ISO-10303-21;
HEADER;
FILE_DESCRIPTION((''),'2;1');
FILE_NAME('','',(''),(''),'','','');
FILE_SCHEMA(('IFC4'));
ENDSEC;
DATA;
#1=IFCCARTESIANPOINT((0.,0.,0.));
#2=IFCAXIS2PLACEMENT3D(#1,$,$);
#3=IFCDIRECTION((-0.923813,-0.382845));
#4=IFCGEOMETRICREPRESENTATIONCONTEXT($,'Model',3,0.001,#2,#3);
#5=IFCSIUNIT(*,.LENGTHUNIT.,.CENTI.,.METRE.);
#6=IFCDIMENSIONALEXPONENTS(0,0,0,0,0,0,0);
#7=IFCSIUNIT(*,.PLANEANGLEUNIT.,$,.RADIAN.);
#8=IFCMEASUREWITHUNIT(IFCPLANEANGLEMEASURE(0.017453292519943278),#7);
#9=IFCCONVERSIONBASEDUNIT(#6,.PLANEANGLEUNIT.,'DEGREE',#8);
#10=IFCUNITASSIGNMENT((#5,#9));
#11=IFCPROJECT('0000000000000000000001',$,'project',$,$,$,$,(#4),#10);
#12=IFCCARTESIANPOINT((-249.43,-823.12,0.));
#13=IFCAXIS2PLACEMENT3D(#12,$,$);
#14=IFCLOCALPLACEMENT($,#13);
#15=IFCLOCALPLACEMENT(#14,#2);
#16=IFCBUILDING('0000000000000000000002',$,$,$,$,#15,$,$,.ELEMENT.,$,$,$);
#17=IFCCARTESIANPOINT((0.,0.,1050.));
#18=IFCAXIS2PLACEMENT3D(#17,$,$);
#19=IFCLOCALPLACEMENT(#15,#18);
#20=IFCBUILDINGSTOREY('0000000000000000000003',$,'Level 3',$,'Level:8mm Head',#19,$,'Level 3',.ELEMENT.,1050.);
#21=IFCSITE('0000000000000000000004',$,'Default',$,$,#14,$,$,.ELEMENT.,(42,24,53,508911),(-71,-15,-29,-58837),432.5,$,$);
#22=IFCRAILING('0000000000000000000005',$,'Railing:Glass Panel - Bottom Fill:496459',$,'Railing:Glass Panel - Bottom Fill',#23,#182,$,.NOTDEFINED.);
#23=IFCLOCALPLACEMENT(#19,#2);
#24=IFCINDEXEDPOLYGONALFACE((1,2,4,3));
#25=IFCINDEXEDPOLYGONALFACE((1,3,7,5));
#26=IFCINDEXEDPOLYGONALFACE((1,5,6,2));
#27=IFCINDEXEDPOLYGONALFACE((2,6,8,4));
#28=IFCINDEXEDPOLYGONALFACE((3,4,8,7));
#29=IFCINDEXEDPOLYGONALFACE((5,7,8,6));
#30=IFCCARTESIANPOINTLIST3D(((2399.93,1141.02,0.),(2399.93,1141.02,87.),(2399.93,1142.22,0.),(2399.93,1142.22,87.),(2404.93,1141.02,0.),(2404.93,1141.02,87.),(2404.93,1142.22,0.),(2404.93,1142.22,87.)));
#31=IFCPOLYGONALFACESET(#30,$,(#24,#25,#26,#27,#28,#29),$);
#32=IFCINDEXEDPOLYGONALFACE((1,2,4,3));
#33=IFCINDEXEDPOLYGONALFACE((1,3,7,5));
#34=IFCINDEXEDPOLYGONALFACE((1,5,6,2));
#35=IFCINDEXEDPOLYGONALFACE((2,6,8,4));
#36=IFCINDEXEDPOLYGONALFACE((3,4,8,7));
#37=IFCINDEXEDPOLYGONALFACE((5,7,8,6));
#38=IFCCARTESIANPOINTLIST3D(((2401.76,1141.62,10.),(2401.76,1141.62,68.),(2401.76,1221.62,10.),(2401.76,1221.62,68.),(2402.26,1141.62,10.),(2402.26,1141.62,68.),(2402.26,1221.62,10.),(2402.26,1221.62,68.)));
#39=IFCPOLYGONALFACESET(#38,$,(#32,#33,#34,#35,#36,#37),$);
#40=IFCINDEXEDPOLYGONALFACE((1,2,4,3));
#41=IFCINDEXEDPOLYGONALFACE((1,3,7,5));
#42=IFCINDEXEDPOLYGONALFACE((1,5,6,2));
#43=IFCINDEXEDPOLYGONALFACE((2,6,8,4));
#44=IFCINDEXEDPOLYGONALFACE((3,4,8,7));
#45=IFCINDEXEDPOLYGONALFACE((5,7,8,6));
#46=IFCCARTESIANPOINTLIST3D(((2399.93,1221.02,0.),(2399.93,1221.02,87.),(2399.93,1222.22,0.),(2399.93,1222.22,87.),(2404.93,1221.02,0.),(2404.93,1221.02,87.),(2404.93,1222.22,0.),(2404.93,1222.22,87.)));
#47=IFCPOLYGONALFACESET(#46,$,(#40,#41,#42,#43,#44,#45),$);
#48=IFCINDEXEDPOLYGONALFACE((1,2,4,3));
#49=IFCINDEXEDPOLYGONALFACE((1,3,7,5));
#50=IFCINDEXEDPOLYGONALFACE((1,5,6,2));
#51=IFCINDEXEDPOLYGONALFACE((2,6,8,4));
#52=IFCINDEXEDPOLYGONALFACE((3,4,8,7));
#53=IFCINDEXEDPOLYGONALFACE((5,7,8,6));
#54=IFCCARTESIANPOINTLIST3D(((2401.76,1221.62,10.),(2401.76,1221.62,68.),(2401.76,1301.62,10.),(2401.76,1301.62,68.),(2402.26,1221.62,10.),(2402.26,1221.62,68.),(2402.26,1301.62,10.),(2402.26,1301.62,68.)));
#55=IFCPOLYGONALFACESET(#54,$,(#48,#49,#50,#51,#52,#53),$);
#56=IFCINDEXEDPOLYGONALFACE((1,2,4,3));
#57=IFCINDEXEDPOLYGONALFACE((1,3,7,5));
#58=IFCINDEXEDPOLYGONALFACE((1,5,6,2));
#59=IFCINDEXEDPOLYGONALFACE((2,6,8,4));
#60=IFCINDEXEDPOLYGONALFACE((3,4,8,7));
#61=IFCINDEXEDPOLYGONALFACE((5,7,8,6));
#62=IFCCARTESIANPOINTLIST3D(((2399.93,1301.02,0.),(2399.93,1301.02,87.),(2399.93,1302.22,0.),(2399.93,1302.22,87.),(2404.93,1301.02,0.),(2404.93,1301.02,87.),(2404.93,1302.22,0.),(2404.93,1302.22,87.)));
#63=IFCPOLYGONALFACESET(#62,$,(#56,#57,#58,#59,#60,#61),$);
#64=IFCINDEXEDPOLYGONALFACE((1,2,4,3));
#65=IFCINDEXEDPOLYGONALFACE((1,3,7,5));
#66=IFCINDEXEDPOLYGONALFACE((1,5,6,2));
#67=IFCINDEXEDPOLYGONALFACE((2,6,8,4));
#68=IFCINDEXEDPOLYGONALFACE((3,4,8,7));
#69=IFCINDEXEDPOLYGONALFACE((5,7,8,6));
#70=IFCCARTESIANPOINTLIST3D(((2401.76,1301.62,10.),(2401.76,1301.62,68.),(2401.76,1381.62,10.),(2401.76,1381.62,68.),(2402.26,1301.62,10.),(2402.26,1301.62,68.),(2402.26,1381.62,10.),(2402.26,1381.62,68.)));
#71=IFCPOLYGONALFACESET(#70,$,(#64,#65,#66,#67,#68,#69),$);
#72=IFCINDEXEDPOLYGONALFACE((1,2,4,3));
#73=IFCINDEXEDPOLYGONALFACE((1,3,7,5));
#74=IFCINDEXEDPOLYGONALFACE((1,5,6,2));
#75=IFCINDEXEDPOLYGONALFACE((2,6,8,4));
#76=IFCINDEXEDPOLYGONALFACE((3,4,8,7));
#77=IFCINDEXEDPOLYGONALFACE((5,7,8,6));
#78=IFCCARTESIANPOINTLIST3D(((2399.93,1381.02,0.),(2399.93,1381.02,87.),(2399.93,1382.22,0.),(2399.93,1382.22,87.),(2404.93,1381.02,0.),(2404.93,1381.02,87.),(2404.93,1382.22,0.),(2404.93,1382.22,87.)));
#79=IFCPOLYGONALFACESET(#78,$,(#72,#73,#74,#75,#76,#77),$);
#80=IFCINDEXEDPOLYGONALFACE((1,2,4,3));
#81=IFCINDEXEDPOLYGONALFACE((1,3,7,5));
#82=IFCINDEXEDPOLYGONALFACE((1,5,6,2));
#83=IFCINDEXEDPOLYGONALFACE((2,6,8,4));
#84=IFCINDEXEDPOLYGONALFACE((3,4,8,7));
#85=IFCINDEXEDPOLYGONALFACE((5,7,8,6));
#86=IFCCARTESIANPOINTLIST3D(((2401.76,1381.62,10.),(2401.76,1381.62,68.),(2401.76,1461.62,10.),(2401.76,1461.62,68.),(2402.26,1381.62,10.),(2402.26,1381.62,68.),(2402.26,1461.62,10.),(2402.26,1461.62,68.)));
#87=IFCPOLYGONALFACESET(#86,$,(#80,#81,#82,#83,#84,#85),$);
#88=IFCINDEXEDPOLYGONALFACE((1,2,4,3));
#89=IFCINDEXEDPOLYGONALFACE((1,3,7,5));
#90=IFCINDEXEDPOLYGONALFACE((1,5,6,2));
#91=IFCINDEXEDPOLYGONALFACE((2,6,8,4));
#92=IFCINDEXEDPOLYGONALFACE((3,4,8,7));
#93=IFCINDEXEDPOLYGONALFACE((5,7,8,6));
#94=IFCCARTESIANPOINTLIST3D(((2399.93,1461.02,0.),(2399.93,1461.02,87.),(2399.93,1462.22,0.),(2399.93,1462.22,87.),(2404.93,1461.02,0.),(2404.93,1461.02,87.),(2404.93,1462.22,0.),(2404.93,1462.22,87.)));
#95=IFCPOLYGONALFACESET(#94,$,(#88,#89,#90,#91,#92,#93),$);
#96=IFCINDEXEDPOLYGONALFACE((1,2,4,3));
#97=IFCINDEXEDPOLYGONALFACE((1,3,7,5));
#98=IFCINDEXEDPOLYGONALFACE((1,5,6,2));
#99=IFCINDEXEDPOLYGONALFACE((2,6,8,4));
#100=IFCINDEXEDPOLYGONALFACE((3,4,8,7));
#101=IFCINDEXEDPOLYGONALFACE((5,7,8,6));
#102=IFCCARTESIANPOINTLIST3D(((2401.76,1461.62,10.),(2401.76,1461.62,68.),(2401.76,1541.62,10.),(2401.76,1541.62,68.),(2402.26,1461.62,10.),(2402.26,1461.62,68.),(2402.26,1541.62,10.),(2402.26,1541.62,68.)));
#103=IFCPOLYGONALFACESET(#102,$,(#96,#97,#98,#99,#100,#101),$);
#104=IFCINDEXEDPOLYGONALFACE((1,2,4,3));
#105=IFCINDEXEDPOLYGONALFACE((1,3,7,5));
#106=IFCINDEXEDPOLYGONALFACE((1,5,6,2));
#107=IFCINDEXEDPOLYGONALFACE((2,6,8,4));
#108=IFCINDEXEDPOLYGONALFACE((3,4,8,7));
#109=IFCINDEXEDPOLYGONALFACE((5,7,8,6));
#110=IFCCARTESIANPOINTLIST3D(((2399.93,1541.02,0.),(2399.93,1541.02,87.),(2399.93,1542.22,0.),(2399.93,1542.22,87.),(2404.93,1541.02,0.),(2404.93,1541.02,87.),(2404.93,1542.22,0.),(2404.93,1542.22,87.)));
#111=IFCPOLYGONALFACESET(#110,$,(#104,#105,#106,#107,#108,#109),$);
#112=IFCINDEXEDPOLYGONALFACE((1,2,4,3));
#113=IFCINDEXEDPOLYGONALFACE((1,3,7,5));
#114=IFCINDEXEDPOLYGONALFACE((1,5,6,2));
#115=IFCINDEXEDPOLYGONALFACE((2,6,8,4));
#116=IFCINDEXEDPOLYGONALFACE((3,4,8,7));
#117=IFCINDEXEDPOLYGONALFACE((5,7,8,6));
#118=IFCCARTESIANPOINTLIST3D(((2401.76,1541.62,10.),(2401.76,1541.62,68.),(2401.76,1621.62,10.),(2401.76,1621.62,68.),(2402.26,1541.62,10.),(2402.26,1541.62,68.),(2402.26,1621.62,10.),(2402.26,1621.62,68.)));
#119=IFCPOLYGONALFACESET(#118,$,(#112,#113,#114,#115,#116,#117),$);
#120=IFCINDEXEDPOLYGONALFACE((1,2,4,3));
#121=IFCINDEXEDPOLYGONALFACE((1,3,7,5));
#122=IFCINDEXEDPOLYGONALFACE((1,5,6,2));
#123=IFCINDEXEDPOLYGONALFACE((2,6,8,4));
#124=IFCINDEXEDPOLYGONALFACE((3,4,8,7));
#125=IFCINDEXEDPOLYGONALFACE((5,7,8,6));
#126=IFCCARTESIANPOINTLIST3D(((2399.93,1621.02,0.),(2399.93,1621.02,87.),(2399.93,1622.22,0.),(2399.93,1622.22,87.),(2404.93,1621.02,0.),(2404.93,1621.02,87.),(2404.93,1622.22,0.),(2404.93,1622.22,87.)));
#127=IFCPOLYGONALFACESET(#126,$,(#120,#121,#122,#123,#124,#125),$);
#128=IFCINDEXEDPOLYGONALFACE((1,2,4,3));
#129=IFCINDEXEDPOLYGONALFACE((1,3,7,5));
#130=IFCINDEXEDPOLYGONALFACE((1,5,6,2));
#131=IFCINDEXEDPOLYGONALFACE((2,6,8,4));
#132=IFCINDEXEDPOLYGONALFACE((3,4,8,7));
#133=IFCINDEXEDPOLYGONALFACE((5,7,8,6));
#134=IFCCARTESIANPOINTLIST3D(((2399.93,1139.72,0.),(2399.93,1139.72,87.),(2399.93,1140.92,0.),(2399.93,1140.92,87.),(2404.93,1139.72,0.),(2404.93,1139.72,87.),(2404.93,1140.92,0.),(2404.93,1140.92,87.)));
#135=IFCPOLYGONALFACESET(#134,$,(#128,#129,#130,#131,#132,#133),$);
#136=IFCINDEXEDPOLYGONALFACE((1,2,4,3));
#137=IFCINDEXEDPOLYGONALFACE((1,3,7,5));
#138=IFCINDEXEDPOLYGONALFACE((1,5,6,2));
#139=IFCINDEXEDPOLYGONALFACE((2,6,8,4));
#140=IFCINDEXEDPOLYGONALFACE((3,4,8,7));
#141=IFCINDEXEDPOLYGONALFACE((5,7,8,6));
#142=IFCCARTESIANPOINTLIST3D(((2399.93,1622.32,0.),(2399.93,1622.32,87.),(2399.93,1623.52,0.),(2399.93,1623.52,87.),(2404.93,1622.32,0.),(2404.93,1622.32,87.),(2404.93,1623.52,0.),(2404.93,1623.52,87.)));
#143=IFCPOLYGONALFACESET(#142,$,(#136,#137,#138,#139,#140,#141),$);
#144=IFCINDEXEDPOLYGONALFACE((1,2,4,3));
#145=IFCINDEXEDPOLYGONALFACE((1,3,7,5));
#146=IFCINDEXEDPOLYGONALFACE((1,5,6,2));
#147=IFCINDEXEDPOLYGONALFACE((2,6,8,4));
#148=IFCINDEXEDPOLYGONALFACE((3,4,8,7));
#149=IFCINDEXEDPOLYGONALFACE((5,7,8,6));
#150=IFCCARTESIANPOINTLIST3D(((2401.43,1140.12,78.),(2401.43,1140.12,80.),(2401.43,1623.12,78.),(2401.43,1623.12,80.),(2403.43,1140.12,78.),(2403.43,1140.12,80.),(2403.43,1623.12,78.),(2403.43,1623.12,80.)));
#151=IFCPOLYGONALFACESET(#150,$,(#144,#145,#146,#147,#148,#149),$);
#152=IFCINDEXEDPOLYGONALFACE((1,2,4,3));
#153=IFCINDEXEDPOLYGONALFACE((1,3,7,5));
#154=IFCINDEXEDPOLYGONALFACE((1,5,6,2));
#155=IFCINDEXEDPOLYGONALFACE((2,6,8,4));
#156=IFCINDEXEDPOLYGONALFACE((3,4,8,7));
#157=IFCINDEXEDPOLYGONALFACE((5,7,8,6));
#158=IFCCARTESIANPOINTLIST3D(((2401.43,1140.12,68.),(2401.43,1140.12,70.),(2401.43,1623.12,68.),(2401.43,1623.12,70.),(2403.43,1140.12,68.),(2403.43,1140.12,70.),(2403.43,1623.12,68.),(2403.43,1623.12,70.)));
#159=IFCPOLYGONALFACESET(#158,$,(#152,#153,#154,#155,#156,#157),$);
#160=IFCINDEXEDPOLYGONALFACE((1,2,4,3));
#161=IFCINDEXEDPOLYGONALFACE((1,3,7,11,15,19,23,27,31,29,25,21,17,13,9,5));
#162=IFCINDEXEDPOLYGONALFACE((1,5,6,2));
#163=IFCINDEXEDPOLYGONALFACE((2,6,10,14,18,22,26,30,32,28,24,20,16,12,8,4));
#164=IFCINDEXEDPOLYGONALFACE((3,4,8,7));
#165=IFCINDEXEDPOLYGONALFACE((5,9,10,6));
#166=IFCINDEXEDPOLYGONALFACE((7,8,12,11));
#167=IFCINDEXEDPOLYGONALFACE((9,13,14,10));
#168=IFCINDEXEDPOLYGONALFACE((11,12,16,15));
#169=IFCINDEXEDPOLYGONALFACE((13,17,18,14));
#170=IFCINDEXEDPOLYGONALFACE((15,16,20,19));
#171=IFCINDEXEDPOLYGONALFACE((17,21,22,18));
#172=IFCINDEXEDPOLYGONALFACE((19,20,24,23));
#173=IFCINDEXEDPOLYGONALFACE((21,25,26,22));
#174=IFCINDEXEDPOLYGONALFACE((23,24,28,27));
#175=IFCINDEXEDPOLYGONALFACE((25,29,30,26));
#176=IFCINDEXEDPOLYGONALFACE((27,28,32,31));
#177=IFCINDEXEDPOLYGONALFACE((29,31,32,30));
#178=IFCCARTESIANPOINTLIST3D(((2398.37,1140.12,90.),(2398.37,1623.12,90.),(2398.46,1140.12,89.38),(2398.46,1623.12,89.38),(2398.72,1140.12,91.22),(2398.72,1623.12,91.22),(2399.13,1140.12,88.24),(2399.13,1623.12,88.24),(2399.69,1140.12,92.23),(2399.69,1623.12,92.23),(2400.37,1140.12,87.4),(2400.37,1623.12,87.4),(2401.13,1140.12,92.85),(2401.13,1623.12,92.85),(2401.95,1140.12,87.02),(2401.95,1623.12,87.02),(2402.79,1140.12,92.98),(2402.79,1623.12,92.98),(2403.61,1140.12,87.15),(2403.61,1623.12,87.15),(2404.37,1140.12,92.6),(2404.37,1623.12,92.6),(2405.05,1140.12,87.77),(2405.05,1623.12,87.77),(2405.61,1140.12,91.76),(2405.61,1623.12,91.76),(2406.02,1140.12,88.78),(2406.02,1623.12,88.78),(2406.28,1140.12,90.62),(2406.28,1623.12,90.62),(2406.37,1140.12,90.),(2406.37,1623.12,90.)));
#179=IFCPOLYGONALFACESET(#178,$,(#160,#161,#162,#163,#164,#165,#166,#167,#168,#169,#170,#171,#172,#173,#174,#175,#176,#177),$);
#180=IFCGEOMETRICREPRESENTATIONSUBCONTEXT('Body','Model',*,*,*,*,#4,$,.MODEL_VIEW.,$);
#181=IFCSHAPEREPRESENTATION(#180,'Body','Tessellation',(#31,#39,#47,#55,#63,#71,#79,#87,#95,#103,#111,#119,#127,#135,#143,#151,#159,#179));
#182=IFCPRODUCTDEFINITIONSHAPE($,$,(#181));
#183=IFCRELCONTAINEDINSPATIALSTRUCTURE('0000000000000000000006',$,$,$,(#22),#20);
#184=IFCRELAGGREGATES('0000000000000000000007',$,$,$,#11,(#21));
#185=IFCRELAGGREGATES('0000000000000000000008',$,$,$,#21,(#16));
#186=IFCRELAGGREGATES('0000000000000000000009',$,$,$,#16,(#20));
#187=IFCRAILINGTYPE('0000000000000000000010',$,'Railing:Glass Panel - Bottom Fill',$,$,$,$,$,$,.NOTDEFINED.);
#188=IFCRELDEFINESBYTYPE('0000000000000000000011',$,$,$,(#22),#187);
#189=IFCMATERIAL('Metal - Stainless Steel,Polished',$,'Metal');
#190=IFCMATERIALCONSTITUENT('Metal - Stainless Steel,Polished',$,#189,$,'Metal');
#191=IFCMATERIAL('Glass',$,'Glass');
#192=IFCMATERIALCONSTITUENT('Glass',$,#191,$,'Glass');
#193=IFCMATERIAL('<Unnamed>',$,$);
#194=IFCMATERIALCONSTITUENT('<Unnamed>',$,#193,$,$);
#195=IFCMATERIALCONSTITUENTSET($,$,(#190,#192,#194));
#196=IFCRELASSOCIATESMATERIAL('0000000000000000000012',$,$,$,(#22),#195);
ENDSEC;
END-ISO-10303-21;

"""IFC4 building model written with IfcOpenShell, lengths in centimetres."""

from ifc_helpers import new_model, entity, si_unit, converted_unit, direction, frame, origin, place, context, subcontext, project, spatial, indexed_curve, outline, extrude, material, constituent, constituent_set, type_object, element, save


model = new_model("IFC4")

# Units and contexts
model_context = context("Model", 3, precision=0.001, world=origin(), true_north=direction((-0.923813, -0.382845)))
body_context = subcontext(model_context, "Body", "Model", "MODEL_VIEW")
ifc_project = project(units=[si_unit("LENGTHUNIT", "METRE", prefix="CENTI"), converted_unit("PLANEANGLEUNIT", "DEGREE", entity("IfcPlaneAngleMeasure", 0.017453292519943278), si_unit("PLANEANGLEUNIT", "RADIAN"), dimensions=[0, 0, 0, 0, 0, 0, 0])], contexts=[model_context])

# Site, building, storey
site_placement = place(None, frame((-249.43, -823.12, 0.0)))
site = spatial("IfcSite", under=ifc_project, at=site_placement, Name="Default", CompositionType="ELEMENT", RefLatitude=(42, 24, 53, 508911), RefLongitude=(-71, -15, -29, -58837), RefElevation=432.5)
building_placement = place(site_placement, origin())
building = spatial("IfcBuilding", under=site, at=building_placement, CompositionType="ELEMENT")
storey_placement = place(building_placement, frame((0.0, 0.0, 1050.0)))
storey = spatial("IfcBuildingStorey", under=building, at=storey_placement, Name="Level 3", ObjectType="Level:8mm Head", LongName="Level 3", CompositionType="ELEMENT", Elevation=1050.0)

# Railing
ifc_material_1 = material(Name="Metal - Stainless Steel,Polished", Category="Metal")
ifc_constituent_1 = constituent(ifc_material_1, Name="Metal - Stainless Steel,Polished", Category="Metal")
ifc_material_2 = material(Name="Glass", Category="Glass")
ifc_constituent_2 = constituent(ifc_material_2, Name="Glass", Category="Glass")
ifc_material_3 = material(Name="<Unnamed>")
ifc_constituent_3 = constituent(ifc_material_3, Name="<Unnamed>")
ifc_constituent_set = constituent_set(constituents=[ifc_constituent_1, ifc_constituent_2, ifc_constituent_3])
railing_type = type_object("IfcRailingType", Name="Railing:Glass Panel - Bottom Fill", PredefinedType="NOTDEFINED")
railing_placement = place(storey_placement, origin())
element("IfcRailing", 1, at=railing_placement, inside=storey, type_object=railing_type, material=ifc_constituent_set, Name="Railing:Glass Panel - Bottom Fill:496459", ObjectType="Railing:Glass Panel - Bottom Fill", PredefinedType="NOTDEFINED", context=body_context, shape_type="SweptSolid", body=[
    extrude(outline(indexed_curve([(-2.5, -0.6), (2.5, -0.6), (2.5, 0.6), (-2.5, 0.6), (-2.5, -0.6)], self_intersect=False)), frame((2402.43, 1141.62, 0.0), z_axis=(0.0, 0.0, 1.0), x_axis=(-1.0, 0.0, 0.0)), (0.0, 0.0, 1.0), 87.0),
    extrude(outline(indexed_curve([(-0.25, -40.0), (0.25, -40.0), (0.25, 40.0), (-0.25, 40.0), (-0.25, -40.0)], self_intersect=False)), frame((2402.01, 1181.62, 10.0), z_axis=(0.0, 0.0, 1.0), x_axis=(-1.0, 0.0, 0.0)), (0.0, 0.0, 1.0), 58.0),
    extrude(outline(indexed_curve([(-2.5, -0.6), (2.5, -0.6), (2.5, 0.6), (-2.5, 0.6), (-2.5, -0.6)], self_intersect=False)), frame((2402.43, 1221.62, 0.0), z_axis=(0.0, 0.0, 1.0), x_axis=(-1.0, 0.0, 0.0)), (0.0, 0.0, 1.0), 87.0),
    extrude(outline(indexed_curve([(-0.25, -40.0), (0.25, -40.0), (0.25, 40.0), (-0.25, 40.0), (-0.25, -40.0)], self_intersect=False)), frame((2402.01, 1261.62, 10.0), z_axis=(0.0, 0.0, 1.0), x_axis=(-1.0, 0.0, 0.0)), (0.0, 0.0, 1.0), 58.0),
    extrude(outline(indexed_curve([(-2.5, -0.6), (2.5, -0.6), (2.5, 0.6), (-2.5, 0.6), (-2.5, -0.6)], self_intersect=False)), frame((2402.43, 1301.62, 0.0), z_axis=(0.0, 0.0, 1.0), x_axis=(-1.0, 0.0, 0.0)), (0.0, 0.0, 1.0), 87.0),
    extrude(outline(indexed_curve([(-0.25, -40.0), (0.25, -40.0), (0.25, 40.0), (-0.25, 40.0), (-0.25, -40.0)], self_intersect=False)), frame((2402.01, 1341.62, 10.0), z_axis=(0.0, 0.0, 1.0), x_axis=(-1.0, 0.0, 0.0)), (0.0, 0.0, 1.0), 58.0),
    extrude(outline(indexed_curve([(-2.5, -0.6), (2.5, -0.6), (2.5, 0.6), (-2.5, 0.6), (-2.5, -0.6)], self_intersect=False)), frame((2402.43, 1381.62, 0.0), z_axis=(0.0, 0.0, 1.0), x_axis=(-1.0, 0.0, 0.0)), (0.0, 0.0, 1.0), 87.0),
    extrude(outline(indexed_curve([(-0.25, -40.0), (0.25, -40.0), (0.25, 40.0), (-0.25, 40.0), (-0.25, -40.0)], self_intersect=False)), frame((2402.01, 1421.62, 10.0), z_axis=(0.0, 0.0, 1.0), x_axis=(-1.0, 0.0, 0.0)), (0.0, 0.0, 1.0), 58.0),
    extrude(outline(indexed_curve([(-2.5, -0.6), (2.5, -0.6), (2.5, 0.6), (-2.5, 0.6), (-2.5, -0.6)], self_intersect=False)), frame((2402.43, 1461.62, 0.0), z_axis=(0.0, 0.0, 1.0), x_axis=(-1.0, 0.0, 0.0)), (0.0, 0.0, 1.0), 87.0),
    extrude(outline(indexed_curve([(-0.25, -40.0), (0.25, -40.0), (0.25, 40.0), (-0.25, 40.0), (-0.25, -40.0)], self_intersect=False)), frame((2402.01, 1501.62, 10.0), z_axis=(0.0, 0.0, 1.0), x_axis=(-1.0, 0.0, 0.0)), (0.0, 0.0, 1.0), 58.0),
    extrude(outline(indexed_curve([(-2.5, -0.6), (2.5, -0.6), (2.5, 0.6), (-2.5, 0.6), (-2.5, -0.6)], self_intersect=False)), frame((2402.43, 1541.62, 0.0), z_axis=(0.0, 0.0, 1.0), x_axis=(-1.0, 0.0, 0.0)), (0.0, 0.0, 1.0), 87.0),
    extrude(outline(indexed_curve([(-0.25, -40.0), (0.25, -40.0), (0.25, 40.0), (-0.25, 40.0), (-0.25, -40.0)], self_intersect=False)), frame((2402.01, 1581.62, 10.0), z_axis=(0.0, 0.0, 1.0), x_axis=(-1.0, 0.0, 0.0)), (0.0, 0.0, 1.0), 58.0),
    extrude(outline(indexed_curve([(-2.5, -0.6), (2.5, -0.6), (2.5, 0.6), (-2.5, 0.6), (-2.5, -0.6)], self_intersect=False)), frame((2402.43, 1621.62, 0.0), z_axis=(0.0, 0.0, 1.0), x_axis=(-1.0, 0.0, 0.0)), (0.0, 0.0, 1.0), 87.0),
    extrude(outline(indexed_curve([(-2.5, -0.6), (2.5, -0.6), (2.5, 0.6), (-2.5, 0.6), (-2.5, -0.6)], self_intersect=False)), frame((2402.43, 1140.32, 0.0), z_axis=(0.0, 0.0, 1.0), x_axis=(-1.0, 0.0, 0.0)), (0.0, 0.0, 1.0), 87.0),
    extrude(outline(indexed_curve([(-2.5, -0.6), (2.5, -0.6), (2.5, 0.6), (-2.5, 0.6), (-2.5, -0.6)], self_intersect=False)), frame((2402.43, 1622.92, 0.0), z_axis=(0.0, 0.0, 1.0), x_axis=(-1.0, 0.0, 0.0)), (0.0, 0.0, 1.0), 87.0),
    extrude(outline(indexed_curve([(-241.5, -1.0), (241.5, -1.0), (241.5, 1.0), (-241.5, 1.0), (-241.5, -1.0)], self_intersect=False)), frame((2402.43, 1381.62, 78.0), z_axis=(0.0, 0.0, 1.0), x_axis=(0.0, -1.0, 0.0)), (0.0, 0.0, 1.0), 2.0),
    extrude(outline(indexed_curve([(-241.5, -1.0), (241.5, -1.0), (241.5, 1.0), (-241.5, 1.0), (-241.5, -1.0)], self_intersect=False)), frame((2402.43, 1381.62, 68.0), z_axis=(0.0, 0.0, 1.0), x_axis=(0.0, -1.0, 0.0)), (0.0, 0.0, 1.0), 2.0),
    extrude(outline(indexed_curve([(-1.09, -3.85), (0.18, -3.85), (1.42, -3.18), (2.41, -1.97), (2.98, -0.41), (3.04, 1.22), (2.58, 2.63), (1.67, 3.59), (1.09, 3.85), (-0.18, 3.85), (-1.42, 3.18), (-2.41, 1.97), (-2.98, 0.41), (-3.04, -1.22), (-2.58, -2.63), (-1.67, -3.59), (-1.09, -3.85)], self_intersect=False)), frame((2402.37, 1140.12, 90.0), z_axis=(0.0, 1.0, 0.0), x_axis=(-0.27267, 0.0, -0.962108)), (0.0, 0.0, 1.0), 483.0),
])

save(model, "model.ifc")
